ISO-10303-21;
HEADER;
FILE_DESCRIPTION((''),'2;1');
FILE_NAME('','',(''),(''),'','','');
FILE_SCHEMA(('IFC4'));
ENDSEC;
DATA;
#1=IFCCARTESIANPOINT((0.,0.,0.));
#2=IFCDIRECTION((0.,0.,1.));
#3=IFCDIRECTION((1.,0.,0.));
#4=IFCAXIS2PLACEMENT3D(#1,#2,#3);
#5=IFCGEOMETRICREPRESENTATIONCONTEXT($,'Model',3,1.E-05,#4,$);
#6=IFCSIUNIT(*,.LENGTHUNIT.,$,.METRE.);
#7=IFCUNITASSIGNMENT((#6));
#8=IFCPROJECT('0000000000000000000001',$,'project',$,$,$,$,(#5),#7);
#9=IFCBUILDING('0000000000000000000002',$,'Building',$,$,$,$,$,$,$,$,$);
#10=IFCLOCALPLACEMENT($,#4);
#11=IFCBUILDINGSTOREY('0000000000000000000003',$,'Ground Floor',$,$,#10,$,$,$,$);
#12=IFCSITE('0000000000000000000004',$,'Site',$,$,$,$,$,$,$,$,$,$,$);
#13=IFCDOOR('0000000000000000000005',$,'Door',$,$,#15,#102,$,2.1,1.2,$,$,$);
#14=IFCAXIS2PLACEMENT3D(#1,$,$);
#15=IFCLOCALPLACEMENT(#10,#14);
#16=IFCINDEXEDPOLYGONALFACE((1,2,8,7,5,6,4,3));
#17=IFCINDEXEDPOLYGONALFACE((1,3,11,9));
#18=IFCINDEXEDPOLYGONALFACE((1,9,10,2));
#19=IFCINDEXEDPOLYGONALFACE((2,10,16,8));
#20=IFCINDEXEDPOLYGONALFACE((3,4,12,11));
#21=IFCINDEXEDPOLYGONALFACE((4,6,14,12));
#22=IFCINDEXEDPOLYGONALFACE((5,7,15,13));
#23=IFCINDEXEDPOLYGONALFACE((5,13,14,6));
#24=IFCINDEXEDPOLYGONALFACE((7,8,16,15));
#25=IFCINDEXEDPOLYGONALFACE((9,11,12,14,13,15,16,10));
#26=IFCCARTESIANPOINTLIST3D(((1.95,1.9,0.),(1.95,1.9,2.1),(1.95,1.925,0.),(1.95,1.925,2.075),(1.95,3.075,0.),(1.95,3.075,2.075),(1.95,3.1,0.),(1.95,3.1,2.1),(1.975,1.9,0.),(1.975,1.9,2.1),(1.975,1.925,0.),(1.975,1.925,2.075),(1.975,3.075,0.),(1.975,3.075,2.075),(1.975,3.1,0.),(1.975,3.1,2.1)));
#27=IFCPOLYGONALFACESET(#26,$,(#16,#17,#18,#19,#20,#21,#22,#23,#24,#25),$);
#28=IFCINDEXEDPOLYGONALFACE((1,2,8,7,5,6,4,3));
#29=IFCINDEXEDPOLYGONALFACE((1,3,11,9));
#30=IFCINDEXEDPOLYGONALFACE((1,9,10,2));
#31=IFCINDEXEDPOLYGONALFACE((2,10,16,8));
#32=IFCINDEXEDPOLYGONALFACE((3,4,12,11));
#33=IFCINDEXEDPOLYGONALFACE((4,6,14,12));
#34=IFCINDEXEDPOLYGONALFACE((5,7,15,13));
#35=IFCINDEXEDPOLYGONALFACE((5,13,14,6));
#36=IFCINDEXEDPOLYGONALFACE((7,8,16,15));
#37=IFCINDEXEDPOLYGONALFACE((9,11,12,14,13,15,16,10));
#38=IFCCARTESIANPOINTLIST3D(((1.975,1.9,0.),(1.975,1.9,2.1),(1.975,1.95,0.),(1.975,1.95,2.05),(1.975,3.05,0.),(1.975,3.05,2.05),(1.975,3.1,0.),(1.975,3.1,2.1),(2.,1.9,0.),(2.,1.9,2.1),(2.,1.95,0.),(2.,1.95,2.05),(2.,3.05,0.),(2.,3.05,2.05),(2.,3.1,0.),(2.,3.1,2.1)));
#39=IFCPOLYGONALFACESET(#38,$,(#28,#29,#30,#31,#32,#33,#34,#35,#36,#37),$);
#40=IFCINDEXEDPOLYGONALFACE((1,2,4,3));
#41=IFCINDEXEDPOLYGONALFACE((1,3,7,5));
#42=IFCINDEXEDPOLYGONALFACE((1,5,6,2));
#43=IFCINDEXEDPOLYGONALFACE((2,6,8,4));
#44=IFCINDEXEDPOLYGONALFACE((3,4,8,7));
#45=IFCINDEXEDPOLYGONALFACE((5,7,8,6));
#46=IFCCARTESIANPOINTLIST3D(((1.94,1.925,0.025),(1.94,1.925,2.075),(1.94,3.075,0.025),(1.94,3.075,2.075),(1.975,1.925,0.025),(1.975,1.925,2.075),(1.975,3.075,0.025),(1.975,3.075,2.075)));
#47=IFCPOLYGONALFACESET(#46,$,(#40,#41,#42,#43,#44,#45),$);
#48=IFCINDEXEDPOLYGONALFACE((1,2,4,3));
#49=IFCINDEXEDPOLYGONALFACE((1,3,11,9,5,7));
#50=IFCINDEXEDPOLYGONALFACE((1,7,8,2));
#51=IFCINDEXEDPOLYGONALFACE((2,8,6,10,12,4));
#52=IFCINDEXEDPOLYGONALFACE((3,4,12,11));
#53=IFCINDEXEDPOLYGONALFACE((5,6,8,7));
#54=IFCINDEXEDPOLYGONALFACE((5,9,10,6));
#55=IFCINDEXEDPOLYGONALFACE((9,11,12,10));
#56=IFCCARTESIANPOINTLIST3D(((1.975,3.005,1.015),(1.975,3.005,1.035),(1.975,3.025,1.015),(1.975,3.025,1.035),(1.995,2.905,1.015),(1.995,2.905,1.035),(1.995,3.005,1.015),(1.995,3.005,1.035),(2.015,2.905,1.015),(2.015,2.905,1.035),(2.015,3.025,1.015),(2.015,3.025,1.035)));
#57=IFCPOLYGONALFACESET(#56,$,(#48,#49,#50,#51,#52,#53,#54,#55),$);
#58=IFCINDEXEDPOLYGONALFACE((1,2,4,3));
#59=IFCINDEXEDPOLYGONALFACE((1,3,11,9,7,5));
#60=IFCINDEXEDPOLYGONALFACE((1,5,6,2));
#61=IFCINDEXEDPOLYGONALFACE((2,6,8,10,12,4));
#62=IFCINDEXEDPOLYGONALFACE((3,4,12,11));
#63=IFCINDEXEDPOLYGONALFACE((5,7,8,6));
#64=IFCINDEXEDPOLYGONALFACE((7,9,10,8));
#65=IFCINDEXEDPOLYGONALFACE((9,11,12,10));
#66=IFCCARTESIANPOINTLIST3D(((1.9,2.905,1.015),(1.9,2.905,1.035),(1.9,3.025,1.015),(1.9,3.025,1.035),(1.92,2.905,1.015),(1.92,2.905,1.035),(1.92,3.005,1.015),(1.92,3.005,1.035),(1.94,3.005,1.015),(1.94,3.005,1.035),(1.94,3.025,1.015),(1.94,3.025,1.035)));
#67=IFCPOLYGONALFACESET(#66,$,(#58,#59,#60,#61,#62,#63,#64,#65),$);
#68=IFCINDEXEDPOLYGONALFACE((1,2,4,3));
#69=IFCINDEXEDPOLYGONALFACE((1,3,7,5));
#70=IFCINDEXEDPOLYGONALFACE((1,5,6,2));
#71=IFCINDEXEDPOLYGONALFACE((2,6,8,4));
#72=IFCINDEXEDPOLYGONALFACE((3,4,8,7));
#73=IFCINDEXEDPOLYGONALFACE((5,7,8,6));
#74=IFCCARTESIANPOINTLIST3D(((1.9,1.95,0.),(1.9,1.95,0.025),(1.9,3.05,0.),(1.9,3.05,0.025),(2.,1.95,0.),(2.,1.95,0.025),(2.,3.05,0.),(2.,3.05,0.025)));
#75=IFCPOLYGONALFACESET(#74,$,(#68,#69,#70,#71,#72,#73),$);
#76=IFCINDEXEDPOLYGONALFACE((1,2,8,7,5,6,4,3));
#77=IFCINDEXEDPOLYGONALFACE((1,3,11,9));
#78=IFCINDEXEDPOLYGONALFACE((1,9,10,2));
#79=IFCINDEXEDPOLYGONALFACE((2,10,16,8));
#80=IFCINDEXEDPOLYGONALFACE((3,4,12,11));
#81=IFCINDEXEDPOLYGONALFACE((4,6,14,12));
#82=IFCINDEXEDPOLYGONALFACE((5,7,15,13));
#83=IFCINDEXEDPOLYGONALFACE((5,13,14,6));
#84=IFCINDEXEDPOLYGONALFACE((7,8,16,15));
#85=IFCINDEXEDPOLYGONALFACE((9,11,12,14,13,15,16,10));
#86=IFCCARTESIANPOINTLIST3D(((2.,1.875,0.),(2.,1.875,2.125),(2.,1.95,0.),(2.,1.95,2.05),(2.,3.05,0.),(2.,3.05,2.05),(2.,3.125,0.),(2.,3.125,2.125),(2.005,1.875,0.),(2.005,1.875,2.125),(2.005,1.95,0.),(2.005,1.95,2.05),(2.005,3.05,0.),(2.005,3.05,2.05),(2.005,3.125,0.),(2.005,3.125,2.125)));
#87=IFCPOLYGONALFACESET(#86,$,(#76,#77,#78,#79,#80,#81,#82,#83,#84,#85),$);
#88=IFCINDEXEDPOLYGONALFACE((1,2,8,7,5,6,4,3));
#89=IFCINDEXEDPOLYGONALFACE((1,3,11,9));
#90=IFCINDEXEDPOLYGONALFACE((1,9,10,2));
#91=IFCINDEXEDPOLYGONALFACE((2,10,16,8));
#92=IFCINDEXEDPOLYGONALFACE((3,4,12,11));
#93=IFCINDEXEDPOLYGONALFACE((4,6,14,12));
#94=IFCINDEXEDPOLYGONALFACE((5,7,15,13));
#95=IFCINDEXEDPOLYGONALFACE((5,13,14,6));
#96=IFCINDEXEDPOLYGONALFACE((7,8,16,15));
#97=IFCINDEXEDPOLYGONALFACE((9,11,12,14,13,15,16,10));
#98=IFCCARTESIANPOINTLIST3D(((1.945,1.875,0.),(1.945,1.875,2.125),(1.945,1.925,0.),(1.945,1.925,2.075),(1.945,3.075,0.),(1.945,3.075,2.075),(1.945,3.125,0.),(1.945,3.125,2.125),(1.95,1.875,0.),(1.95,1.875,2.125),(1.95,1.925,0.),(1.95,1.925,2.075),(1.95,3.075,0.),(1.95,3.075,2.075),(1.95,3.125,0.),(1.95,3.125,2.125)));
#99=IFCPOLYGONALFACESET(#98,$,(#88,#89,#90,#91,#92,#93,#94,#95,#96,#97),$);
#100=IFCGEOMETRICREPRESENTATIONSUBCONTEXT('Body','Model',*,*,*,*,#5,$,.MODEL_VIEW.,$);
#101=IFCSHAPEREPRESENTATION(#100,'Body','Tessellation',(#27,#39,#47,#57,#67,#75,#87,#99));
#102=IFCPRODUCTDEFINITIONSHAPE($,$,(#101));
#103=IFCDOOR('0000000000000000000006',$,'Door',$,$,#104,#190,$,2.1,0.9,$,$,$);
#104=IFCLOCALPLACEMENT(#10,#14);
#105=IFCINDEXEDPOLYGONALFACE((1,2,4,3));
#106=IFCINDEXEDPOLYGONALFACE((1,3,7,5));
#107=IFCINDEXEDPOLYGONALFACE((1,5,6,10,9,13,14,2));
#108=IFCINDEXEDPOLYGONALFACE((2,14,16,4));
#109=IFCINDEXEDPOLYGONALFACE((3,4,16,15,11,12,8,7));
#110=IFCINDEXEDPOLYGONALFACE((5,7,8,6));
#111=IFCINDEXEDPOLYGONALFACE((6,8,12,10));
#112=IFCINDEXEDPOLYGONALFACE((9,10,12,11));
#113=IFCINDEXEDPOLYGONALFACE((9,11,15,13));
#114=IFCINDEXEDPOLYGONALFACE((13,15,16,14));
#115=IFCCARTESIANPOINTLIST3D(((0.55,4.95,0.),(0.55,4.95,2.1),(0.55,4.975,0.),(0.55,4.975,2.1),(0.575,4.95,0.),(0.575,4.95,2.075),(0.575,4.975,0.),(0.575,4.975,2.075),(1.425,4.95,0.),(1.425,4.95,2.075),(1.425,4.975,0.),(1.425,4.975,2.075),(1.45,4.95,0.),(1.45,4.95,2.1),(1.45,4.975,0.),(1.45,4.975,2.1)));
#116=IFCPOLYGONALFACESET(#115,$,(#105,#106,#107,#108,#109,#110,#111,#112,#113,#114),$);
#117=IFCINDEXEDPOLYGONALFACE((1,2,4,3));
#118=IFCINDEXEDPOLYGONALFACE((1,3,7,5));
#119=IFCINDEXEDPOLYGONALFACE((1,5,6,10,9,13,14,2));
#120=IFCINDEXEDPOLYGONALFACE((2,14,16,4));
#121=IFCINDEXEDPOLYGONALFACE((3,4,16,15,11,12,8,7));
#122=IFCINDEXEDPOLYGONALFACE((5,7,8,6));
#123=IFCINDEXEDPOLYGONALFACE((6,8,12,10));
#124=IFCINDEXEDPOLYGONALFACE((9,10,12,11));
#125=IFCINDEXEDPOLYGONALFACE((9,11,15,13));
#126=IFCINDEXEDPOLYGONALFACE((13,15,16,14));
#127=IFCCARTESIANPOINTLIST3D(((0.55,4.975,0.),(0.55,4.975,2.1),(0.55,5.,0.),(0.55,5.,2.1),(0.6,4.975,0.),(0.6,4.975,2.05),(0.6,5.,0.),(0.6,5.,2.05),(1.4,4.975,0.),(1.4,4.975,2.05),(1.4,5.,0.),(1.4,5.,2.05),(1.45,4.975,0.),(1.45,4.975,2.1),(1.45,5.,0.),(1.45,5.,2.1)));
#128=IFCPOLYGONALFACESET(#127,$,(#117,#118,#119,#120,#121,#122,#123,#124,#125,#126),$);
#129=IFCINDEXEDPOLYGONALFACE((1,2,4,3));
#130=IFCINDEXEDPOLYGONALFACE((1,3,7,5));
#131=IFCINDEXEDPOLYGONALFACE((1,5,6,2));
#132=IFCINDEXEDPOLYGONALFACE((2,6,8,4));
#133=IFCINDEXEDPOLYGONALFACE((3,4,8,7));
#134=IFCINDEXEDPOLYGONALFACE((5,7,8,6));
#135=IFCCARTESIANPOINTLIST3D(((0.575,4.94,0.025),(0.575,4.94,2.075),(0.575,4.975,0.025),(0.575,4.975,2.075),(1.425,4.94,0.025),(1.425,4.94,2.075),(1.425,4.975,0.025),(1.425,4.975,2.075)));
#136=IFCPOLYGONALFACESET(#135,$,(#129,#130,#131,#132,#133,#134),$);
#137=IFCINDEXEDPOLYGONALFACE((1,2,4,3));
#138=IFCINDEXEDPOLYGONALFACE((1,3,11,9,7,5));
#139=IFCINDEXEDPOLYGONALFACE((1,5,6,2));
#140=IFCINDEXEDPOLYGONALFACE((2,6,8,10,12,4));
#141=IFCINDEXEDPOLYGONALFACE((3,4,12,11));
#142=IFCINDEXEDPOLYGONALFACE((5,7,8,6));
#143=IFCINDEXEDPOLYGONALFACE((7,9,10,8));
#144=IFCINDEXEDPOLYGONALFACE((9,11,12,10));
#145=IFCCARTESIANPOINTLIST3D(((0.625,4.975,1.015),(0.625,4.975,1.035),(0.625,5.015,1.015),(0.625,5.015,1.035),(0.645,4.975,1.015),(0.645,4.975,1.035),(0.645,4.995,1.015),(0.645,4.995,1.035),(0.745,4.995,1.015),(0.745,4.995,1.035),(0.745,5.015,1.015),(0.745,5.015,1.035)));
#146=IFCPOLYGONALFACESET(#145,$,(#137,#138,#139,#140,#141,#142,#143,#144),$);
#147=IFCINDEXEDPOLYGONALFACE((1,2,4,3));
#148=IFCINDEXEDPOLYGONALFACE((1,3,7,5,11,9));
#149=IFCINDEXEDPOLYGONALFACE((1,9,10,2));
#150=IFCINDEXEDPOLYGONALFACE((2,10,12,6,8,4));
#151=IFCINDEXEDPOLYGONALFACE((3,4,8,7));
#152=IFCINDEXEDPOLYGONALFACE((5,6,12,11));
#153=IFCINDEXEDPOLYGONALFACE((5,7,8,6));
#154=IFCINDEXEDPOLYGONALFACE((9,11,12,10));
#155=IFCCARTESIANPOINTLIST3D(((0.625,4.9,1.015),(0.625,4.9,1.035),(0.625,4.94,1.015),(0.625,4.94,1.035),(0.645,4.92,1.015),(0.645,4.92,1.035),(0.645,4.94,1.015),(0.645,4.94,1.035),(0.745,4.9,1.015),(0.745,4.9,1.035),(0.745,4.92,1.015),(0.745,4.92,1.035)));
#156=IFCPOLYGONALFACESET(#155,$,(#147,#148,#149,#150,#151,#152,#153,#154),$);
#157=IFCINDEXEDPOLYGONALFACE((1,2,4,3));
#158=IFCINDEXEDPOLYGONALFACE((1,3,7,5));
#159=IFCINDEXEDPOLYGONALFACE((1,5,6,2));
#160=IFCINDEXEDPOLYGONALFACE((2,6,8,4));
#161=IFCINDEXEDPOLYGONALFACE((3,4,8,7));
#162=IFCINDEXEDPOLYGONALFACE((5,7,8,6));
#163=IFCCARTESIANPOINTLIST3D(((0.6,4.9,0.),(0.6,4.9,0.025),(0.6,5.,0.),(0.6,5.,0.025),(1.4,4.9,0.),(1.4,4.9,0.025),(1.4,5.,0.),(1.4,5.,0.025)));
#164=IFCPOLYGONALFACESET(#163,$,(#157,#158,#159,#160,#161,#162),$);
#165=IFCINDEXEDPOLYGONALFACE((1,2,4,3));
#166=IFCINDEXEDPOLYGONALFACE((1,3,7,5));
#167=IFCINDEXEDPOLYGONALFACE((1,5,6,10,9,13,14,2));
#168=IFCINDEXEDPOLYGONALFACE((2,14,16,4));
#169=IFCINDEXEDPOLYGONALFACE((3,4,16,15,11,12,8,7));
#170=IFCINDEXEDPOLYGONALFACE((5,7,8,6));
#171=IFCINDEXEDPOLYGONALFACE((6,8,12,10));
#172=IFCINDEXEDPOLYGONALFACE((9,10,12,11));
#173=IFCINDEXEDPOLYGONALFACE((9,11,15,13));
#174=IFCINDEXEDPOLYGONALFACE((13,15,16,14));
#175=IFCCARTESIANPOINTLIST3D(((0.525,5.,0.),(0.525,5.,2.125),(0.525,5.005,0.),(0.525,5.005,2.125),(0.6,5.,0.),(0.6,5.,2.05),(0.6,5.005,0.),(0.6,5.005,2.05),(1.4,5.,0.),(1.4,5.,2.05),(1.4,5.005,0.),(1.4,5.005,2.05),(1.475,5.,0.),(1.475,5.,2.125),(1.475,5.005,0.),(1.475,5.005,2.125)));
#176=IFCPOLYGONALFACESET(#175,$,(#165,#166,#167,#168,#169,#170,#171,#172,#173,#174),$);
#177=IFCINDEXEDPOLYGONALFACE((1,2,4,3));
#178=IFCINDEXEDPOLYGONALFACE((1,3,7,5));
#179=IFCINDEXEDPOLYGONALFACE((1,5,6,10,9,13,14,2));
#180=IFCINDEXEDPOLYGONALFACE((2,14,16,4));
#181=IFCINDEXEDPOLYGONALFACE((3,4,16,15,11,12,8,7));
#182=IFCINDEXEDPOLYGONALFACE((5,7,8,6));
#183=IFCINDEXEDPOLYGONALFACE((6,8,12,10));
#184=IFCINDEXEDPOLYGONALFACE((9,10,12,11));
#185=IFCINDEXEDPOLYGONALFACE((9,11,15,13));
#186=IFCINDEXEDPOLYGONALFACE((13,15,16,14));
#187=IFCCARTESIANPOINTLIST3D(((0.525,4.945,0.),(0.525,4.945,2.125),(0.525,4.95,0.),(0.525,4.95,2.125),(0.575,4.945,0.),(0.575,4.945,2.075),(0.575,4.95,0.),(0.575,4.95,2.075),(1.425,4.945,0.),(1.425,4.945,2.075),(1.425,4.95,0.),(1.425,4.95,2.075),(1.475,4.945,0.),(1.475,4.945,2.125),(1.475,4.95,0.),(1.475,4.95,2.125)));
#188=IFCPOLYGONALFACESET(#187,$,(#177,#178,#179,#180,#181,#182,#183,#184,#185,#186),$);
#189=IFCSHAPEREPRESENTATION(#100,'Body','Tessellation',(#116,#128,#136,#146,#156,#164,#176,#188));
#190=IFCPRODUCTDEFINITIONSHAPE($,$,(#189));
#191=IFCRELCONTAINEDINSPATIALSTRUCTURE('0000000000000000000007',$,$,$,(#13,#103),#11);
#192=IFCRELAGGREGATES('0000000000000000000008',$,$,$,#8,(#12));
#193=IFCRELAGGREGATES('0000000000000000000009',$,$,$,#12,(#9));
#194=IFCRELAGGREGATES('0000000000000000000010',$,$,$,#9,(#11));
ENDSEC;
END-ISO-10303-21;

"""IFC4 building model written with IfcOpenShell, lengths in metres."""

from ifc_helpers import new_model, si_unit, frame, origin_with_axes, place, context, subcontext, project, spatial, line, indexed_curve, outline, extrude, element, save


model = new_model("IFC4")

# Units and contexts
model_context = context("Model", 3, precision=1e-05, world=origin_with_axes())
body_context = subcontext(model_context, "Body", "Model", "MODEL_VIEW")
ifc_project = project(units=[si_unit("LENGTHUNIT", "METRE")], contexts=[model_context])

# Site, building, storey
site = spatial("IfcSite", under=ifc_project, Name="Site")
building = spatial("IfcBuilding", under=site, Name="Building")
storey_placement = place(None, origin_with_axes())
storey = spatial("IfcBuildingStorey", under=building, at=storey_placement, Name="Ground Floor")

# Doors
door_1_placement = place(storey_placement, frame((2.0, 1.9, 0.0), z_axis=(0.0, 0.0, 1.0), x_axis=(0.0, 1.0, 0.0)))
element("IfcDoor", 1, at=door_1_placement, inside=storey, Name="Door", OverallHeight=2.1, OverallWidth=1.2, context=body_context, shape_type="SweptSolid", body=[
    extrude(outline(indexed_curve([(0.0, 0.0), (0.0, 2.1), (1.2, 2.1), (1.2, 0.0), (1.175, 0.0), (1.175, 2.075), (0.025, 2.075), (0.025, 0.0)], segments=[line(1, 2, 3, 4, 5, 6, 7, 8, 1)])), frame((0.0, 0.025, 0.0), z_axis=(0.0, -1.0, 0.0), x_axis=(1.0, 0.0, 0.0)), (0.0, 0.0, -1.0), 0.025),
    extrude(outline(indexed_curve([(0.0, 0.0), (0.0, 2.1), (1.2, 2.1), (1.2, 0.0), (1.15, 0.0), (1.15, 2.05), (0.05, 2.05), (0.05, 0.0)], segments=[line(1, 2, 3, 4, 5, 6, 7, 8, 1)])), frame((0.0, 0.0, 0.0), z_axis=(0.0, -1.0, 0.0), x_axis=(1.0, 0.0, 0.0)), (0.0, 0.0, -1.0), 0.025),
    extrude(outline(indexed_curve([(0.0, 0.0), (1.15, 0.0), (1.15, 0.035), (0.0, 0.035)], segments=[line(1, 2, 3, 4, 1)])), frame((0.025, 0.025, 0.025), z_axis=(0.0, 0.0, 1.0), x_axis=(1.0, 0.0, 0.0)), (0.0, 0.0, 1.0), 2.05),
    extrude(outline(indexed_curve([(0.0, 0.0), (0.0, -0.04), (-0.12, -0.04), (-0.12, -0.02), (-0.02, -0.02), (-0.02, 0.0)], segments=[line(1, 2, 3, 4, 5, 6, 1)])), frame((1.125, 0.025, 1.015), z_axis=(0.0, 0.0, 1.0), x_axis=(1.0, 0.0, 0.0)), (0.0, 0.0, 1.0), 0.02),
    extrude(outline(indexed_curve([(0.0, 0.0), (0.0, 0.04), (-0.12, 0.04), (-0.12, 0.02), (-0.02, 0.02), (-0.02, 0.0)], segments=[line(1, 2, 3, 4, 5, 6, 1)])), frame((1.125, 0.06, 1.015), z_axis=(0.0, 0.0, 1.0), x_axis=(1.0, 0.0, 0.0)), (0.0, 0.0, 1.0), 0.02),
    extrude(outline(indexed_curve([(0.0, 0.0), (1.1, 0.0), (1.1, 0.1), (0.0, 0.1)], segments=[line(1, 2, 3, 4, 1)])), frame((0.05, 0.0, 0.0), z_axis=(0.0, 0.0, 1.0), x_axis=(1.0, 0.0, 0.0)), (0.0, 0.0, 1.0), 0.025),
    extrude(outline(indexed_curve([(0.0, 0.0), (0.0, 2.125), (1.25, 2.125), (1.25, 0.0), (1.175, 0.0), (1.175, 2.05), (0.075, 2.05), (0.075, 0.0)], segments=[line(1, 2, 3, 4, 5, 6, 7, 8, 1)])), frame((-0.025, -0.005, 0.0), z_axis=(0.0, -1.0, 0.0), x_axis=(1.0, 0.0, 0.0)), (0.0, 0.0, -1.0), 0.005),
    extrude(outline(indexed_curve([(0.0, 0.0), (0.0, 2.125), (1.25, 2.125), (1.25, 0.0), (1.2, 0.0), (1.2, 2.075), (0.05, 2.075), (0.05, 0.0)], segments=[line(1, 2, 3, 4, 5, 6, 7, 8, 1)])), frame((-0.025, 0.05, 0.0), z_axis=(0.0, -1.0, 0.0), x_axis=(1.0, 0.0, 0.0)), (0.0, 0.0, -1.0), 0.005),
])
door_2_placement = place(storey_placement, frame((1.45, 5.0, 0.0), z_axis=(0.0, 0.0, 1.0), x_axis=(-1.0, 0.0, 0.0)))
element("IfcDoor", 2, at=door_2_placement, inside=storey, Name="Door", OverallHeight=2.1, OverallWidth=0.9, context=body_context, shape_type="SweptSolid", body=[
    extrude(outline(indexed_curve([(0.0, 0.0), (0.0, 2.1), (0.9, 2.1), (0.9, 0.0), (0.875, 0.0), (0.875, 2.075), (0.025, 2.075), (0.025, 0.0)], segments=[line(1, 2, 3, 4, 5, 6, 7, 8, 1)])), frame((0.0, 0.025, 0.0), z_axis=(0.0, -1.0, 0.0), x_axis=(1.0, 0.0, 0.0)), (0.0, 0.0, -1.0), 0.025),
    extrude(outline(indexed_curve([(0.0, 0.0), (0.0, 2.1), (0.9, 2.1), (0.9, 0.0), (0.85, 0.0), (0.85, 2.05), (0.05, 2.05), (0.05, 0.0)], segments=[line(1, 2, 3, 4, 5, 6, 7, 8, 1)])), frame((0.0, 0.0, 0.0), z_axis=(0.0, -1.0, 0.0), x_axis=(1.0, 0.0, 0.0)), (0.0, 0.0, -1.0), 0.025),
    extrude(outline(indexed_curve([(0.0, 0.0), (0.85, 0.0), (0.85, 0.035), (0.0, 0.035)], segments=[line(1, 2, 3, 4, 1)])), frame((0.025, 0.025, 0.025), z_axis=(0.0, 0.0, 1.0), x_axis=(1.0, 0.0, 0.0)), (0.0, 0.0, 1.0), 2.05),
    extrude(outline(indexed_curve([(0.0, 0.0), (0.0, -0.04), (-0.12, -0.04), (-0.12, -0.02), (-0.02, -0.02), (-0.02, 0.0)], segments=[line(1, 2, 3, 4, 5, 6, 1)])), frame((0.825, 0.025, 1.015), z_axis=(0.0, 0.0, 1.0), x_axis=(1.0, 0.0, 0.0)), (0.0, 0.0, 1.0), 0.02),
    extrude(outline(indexed_curve([(0.0, 0.0), (0.0, 0.04), (-0.12, 0.04), (-0.12, 0.02), (-0.02, 0.02), (-0.02, 0.0)], segments=[line(1, 2, 3, 4, 5, 6, 1)])), frame((0.825, 0.06, 1.015), z_axis=(0.0, 0.0, 1.0), x_axis=(1.0, 0.0, 0.0)), (0.0, 0.0, 1.0), 0.02),
    extrude(outline(indexed_curve([(0.0, 0.0), (0.8, 0.0), (0.8, 0.1), (0.0, 0.1)], segments=[line(1, 2, 3, 4, 1)])), frame((0.05, 0.0, 0.0), z_axis=(0.0, 0.0, 1.0), x_axis=(1.0, 0.0, 0.0)), (0.0, 0.0, 1.0), 0.025),
    extrude(outline(indexed_curve([(0.0, 0.0), (0.0, 2.125), (0.95, 2.125), (0.95, 0.0), (0.875, 0.0), (0.875, 2.05), (0.075, 2.05), (0.075, 0.0)], segments=[line(1, 2, 3, 4, 5, 6, 7, 8, 1)])), frame((-0.025, -0.005, 0.0), z_axis=(0.0, -1.0, 0.0), x_axis=(1.0, 0.0, 0.0)), (0.0, 0.0, -1.0), 0.005),
    extrude(outline(indexed_curve([(0.0, 0.0), (0.0, 2.125), (0.95, 2.125), (0.95, 0.0), (0.9, 0.0), (0.9, 2.075), (0.05, 2.075), (0.05, 0.0)], segments=[line(1, 2, 3, 4, 5, 6, 7, 8, 1)])), frame((-0.025, 0.05, 0.0), z_axis=(0.0, -1.0, 0.0), x_axis=(1.0, 0.0, 0.0)), (0.0, 0.0, -1.0), 0.005),
])

save(model, "model.ifc")
